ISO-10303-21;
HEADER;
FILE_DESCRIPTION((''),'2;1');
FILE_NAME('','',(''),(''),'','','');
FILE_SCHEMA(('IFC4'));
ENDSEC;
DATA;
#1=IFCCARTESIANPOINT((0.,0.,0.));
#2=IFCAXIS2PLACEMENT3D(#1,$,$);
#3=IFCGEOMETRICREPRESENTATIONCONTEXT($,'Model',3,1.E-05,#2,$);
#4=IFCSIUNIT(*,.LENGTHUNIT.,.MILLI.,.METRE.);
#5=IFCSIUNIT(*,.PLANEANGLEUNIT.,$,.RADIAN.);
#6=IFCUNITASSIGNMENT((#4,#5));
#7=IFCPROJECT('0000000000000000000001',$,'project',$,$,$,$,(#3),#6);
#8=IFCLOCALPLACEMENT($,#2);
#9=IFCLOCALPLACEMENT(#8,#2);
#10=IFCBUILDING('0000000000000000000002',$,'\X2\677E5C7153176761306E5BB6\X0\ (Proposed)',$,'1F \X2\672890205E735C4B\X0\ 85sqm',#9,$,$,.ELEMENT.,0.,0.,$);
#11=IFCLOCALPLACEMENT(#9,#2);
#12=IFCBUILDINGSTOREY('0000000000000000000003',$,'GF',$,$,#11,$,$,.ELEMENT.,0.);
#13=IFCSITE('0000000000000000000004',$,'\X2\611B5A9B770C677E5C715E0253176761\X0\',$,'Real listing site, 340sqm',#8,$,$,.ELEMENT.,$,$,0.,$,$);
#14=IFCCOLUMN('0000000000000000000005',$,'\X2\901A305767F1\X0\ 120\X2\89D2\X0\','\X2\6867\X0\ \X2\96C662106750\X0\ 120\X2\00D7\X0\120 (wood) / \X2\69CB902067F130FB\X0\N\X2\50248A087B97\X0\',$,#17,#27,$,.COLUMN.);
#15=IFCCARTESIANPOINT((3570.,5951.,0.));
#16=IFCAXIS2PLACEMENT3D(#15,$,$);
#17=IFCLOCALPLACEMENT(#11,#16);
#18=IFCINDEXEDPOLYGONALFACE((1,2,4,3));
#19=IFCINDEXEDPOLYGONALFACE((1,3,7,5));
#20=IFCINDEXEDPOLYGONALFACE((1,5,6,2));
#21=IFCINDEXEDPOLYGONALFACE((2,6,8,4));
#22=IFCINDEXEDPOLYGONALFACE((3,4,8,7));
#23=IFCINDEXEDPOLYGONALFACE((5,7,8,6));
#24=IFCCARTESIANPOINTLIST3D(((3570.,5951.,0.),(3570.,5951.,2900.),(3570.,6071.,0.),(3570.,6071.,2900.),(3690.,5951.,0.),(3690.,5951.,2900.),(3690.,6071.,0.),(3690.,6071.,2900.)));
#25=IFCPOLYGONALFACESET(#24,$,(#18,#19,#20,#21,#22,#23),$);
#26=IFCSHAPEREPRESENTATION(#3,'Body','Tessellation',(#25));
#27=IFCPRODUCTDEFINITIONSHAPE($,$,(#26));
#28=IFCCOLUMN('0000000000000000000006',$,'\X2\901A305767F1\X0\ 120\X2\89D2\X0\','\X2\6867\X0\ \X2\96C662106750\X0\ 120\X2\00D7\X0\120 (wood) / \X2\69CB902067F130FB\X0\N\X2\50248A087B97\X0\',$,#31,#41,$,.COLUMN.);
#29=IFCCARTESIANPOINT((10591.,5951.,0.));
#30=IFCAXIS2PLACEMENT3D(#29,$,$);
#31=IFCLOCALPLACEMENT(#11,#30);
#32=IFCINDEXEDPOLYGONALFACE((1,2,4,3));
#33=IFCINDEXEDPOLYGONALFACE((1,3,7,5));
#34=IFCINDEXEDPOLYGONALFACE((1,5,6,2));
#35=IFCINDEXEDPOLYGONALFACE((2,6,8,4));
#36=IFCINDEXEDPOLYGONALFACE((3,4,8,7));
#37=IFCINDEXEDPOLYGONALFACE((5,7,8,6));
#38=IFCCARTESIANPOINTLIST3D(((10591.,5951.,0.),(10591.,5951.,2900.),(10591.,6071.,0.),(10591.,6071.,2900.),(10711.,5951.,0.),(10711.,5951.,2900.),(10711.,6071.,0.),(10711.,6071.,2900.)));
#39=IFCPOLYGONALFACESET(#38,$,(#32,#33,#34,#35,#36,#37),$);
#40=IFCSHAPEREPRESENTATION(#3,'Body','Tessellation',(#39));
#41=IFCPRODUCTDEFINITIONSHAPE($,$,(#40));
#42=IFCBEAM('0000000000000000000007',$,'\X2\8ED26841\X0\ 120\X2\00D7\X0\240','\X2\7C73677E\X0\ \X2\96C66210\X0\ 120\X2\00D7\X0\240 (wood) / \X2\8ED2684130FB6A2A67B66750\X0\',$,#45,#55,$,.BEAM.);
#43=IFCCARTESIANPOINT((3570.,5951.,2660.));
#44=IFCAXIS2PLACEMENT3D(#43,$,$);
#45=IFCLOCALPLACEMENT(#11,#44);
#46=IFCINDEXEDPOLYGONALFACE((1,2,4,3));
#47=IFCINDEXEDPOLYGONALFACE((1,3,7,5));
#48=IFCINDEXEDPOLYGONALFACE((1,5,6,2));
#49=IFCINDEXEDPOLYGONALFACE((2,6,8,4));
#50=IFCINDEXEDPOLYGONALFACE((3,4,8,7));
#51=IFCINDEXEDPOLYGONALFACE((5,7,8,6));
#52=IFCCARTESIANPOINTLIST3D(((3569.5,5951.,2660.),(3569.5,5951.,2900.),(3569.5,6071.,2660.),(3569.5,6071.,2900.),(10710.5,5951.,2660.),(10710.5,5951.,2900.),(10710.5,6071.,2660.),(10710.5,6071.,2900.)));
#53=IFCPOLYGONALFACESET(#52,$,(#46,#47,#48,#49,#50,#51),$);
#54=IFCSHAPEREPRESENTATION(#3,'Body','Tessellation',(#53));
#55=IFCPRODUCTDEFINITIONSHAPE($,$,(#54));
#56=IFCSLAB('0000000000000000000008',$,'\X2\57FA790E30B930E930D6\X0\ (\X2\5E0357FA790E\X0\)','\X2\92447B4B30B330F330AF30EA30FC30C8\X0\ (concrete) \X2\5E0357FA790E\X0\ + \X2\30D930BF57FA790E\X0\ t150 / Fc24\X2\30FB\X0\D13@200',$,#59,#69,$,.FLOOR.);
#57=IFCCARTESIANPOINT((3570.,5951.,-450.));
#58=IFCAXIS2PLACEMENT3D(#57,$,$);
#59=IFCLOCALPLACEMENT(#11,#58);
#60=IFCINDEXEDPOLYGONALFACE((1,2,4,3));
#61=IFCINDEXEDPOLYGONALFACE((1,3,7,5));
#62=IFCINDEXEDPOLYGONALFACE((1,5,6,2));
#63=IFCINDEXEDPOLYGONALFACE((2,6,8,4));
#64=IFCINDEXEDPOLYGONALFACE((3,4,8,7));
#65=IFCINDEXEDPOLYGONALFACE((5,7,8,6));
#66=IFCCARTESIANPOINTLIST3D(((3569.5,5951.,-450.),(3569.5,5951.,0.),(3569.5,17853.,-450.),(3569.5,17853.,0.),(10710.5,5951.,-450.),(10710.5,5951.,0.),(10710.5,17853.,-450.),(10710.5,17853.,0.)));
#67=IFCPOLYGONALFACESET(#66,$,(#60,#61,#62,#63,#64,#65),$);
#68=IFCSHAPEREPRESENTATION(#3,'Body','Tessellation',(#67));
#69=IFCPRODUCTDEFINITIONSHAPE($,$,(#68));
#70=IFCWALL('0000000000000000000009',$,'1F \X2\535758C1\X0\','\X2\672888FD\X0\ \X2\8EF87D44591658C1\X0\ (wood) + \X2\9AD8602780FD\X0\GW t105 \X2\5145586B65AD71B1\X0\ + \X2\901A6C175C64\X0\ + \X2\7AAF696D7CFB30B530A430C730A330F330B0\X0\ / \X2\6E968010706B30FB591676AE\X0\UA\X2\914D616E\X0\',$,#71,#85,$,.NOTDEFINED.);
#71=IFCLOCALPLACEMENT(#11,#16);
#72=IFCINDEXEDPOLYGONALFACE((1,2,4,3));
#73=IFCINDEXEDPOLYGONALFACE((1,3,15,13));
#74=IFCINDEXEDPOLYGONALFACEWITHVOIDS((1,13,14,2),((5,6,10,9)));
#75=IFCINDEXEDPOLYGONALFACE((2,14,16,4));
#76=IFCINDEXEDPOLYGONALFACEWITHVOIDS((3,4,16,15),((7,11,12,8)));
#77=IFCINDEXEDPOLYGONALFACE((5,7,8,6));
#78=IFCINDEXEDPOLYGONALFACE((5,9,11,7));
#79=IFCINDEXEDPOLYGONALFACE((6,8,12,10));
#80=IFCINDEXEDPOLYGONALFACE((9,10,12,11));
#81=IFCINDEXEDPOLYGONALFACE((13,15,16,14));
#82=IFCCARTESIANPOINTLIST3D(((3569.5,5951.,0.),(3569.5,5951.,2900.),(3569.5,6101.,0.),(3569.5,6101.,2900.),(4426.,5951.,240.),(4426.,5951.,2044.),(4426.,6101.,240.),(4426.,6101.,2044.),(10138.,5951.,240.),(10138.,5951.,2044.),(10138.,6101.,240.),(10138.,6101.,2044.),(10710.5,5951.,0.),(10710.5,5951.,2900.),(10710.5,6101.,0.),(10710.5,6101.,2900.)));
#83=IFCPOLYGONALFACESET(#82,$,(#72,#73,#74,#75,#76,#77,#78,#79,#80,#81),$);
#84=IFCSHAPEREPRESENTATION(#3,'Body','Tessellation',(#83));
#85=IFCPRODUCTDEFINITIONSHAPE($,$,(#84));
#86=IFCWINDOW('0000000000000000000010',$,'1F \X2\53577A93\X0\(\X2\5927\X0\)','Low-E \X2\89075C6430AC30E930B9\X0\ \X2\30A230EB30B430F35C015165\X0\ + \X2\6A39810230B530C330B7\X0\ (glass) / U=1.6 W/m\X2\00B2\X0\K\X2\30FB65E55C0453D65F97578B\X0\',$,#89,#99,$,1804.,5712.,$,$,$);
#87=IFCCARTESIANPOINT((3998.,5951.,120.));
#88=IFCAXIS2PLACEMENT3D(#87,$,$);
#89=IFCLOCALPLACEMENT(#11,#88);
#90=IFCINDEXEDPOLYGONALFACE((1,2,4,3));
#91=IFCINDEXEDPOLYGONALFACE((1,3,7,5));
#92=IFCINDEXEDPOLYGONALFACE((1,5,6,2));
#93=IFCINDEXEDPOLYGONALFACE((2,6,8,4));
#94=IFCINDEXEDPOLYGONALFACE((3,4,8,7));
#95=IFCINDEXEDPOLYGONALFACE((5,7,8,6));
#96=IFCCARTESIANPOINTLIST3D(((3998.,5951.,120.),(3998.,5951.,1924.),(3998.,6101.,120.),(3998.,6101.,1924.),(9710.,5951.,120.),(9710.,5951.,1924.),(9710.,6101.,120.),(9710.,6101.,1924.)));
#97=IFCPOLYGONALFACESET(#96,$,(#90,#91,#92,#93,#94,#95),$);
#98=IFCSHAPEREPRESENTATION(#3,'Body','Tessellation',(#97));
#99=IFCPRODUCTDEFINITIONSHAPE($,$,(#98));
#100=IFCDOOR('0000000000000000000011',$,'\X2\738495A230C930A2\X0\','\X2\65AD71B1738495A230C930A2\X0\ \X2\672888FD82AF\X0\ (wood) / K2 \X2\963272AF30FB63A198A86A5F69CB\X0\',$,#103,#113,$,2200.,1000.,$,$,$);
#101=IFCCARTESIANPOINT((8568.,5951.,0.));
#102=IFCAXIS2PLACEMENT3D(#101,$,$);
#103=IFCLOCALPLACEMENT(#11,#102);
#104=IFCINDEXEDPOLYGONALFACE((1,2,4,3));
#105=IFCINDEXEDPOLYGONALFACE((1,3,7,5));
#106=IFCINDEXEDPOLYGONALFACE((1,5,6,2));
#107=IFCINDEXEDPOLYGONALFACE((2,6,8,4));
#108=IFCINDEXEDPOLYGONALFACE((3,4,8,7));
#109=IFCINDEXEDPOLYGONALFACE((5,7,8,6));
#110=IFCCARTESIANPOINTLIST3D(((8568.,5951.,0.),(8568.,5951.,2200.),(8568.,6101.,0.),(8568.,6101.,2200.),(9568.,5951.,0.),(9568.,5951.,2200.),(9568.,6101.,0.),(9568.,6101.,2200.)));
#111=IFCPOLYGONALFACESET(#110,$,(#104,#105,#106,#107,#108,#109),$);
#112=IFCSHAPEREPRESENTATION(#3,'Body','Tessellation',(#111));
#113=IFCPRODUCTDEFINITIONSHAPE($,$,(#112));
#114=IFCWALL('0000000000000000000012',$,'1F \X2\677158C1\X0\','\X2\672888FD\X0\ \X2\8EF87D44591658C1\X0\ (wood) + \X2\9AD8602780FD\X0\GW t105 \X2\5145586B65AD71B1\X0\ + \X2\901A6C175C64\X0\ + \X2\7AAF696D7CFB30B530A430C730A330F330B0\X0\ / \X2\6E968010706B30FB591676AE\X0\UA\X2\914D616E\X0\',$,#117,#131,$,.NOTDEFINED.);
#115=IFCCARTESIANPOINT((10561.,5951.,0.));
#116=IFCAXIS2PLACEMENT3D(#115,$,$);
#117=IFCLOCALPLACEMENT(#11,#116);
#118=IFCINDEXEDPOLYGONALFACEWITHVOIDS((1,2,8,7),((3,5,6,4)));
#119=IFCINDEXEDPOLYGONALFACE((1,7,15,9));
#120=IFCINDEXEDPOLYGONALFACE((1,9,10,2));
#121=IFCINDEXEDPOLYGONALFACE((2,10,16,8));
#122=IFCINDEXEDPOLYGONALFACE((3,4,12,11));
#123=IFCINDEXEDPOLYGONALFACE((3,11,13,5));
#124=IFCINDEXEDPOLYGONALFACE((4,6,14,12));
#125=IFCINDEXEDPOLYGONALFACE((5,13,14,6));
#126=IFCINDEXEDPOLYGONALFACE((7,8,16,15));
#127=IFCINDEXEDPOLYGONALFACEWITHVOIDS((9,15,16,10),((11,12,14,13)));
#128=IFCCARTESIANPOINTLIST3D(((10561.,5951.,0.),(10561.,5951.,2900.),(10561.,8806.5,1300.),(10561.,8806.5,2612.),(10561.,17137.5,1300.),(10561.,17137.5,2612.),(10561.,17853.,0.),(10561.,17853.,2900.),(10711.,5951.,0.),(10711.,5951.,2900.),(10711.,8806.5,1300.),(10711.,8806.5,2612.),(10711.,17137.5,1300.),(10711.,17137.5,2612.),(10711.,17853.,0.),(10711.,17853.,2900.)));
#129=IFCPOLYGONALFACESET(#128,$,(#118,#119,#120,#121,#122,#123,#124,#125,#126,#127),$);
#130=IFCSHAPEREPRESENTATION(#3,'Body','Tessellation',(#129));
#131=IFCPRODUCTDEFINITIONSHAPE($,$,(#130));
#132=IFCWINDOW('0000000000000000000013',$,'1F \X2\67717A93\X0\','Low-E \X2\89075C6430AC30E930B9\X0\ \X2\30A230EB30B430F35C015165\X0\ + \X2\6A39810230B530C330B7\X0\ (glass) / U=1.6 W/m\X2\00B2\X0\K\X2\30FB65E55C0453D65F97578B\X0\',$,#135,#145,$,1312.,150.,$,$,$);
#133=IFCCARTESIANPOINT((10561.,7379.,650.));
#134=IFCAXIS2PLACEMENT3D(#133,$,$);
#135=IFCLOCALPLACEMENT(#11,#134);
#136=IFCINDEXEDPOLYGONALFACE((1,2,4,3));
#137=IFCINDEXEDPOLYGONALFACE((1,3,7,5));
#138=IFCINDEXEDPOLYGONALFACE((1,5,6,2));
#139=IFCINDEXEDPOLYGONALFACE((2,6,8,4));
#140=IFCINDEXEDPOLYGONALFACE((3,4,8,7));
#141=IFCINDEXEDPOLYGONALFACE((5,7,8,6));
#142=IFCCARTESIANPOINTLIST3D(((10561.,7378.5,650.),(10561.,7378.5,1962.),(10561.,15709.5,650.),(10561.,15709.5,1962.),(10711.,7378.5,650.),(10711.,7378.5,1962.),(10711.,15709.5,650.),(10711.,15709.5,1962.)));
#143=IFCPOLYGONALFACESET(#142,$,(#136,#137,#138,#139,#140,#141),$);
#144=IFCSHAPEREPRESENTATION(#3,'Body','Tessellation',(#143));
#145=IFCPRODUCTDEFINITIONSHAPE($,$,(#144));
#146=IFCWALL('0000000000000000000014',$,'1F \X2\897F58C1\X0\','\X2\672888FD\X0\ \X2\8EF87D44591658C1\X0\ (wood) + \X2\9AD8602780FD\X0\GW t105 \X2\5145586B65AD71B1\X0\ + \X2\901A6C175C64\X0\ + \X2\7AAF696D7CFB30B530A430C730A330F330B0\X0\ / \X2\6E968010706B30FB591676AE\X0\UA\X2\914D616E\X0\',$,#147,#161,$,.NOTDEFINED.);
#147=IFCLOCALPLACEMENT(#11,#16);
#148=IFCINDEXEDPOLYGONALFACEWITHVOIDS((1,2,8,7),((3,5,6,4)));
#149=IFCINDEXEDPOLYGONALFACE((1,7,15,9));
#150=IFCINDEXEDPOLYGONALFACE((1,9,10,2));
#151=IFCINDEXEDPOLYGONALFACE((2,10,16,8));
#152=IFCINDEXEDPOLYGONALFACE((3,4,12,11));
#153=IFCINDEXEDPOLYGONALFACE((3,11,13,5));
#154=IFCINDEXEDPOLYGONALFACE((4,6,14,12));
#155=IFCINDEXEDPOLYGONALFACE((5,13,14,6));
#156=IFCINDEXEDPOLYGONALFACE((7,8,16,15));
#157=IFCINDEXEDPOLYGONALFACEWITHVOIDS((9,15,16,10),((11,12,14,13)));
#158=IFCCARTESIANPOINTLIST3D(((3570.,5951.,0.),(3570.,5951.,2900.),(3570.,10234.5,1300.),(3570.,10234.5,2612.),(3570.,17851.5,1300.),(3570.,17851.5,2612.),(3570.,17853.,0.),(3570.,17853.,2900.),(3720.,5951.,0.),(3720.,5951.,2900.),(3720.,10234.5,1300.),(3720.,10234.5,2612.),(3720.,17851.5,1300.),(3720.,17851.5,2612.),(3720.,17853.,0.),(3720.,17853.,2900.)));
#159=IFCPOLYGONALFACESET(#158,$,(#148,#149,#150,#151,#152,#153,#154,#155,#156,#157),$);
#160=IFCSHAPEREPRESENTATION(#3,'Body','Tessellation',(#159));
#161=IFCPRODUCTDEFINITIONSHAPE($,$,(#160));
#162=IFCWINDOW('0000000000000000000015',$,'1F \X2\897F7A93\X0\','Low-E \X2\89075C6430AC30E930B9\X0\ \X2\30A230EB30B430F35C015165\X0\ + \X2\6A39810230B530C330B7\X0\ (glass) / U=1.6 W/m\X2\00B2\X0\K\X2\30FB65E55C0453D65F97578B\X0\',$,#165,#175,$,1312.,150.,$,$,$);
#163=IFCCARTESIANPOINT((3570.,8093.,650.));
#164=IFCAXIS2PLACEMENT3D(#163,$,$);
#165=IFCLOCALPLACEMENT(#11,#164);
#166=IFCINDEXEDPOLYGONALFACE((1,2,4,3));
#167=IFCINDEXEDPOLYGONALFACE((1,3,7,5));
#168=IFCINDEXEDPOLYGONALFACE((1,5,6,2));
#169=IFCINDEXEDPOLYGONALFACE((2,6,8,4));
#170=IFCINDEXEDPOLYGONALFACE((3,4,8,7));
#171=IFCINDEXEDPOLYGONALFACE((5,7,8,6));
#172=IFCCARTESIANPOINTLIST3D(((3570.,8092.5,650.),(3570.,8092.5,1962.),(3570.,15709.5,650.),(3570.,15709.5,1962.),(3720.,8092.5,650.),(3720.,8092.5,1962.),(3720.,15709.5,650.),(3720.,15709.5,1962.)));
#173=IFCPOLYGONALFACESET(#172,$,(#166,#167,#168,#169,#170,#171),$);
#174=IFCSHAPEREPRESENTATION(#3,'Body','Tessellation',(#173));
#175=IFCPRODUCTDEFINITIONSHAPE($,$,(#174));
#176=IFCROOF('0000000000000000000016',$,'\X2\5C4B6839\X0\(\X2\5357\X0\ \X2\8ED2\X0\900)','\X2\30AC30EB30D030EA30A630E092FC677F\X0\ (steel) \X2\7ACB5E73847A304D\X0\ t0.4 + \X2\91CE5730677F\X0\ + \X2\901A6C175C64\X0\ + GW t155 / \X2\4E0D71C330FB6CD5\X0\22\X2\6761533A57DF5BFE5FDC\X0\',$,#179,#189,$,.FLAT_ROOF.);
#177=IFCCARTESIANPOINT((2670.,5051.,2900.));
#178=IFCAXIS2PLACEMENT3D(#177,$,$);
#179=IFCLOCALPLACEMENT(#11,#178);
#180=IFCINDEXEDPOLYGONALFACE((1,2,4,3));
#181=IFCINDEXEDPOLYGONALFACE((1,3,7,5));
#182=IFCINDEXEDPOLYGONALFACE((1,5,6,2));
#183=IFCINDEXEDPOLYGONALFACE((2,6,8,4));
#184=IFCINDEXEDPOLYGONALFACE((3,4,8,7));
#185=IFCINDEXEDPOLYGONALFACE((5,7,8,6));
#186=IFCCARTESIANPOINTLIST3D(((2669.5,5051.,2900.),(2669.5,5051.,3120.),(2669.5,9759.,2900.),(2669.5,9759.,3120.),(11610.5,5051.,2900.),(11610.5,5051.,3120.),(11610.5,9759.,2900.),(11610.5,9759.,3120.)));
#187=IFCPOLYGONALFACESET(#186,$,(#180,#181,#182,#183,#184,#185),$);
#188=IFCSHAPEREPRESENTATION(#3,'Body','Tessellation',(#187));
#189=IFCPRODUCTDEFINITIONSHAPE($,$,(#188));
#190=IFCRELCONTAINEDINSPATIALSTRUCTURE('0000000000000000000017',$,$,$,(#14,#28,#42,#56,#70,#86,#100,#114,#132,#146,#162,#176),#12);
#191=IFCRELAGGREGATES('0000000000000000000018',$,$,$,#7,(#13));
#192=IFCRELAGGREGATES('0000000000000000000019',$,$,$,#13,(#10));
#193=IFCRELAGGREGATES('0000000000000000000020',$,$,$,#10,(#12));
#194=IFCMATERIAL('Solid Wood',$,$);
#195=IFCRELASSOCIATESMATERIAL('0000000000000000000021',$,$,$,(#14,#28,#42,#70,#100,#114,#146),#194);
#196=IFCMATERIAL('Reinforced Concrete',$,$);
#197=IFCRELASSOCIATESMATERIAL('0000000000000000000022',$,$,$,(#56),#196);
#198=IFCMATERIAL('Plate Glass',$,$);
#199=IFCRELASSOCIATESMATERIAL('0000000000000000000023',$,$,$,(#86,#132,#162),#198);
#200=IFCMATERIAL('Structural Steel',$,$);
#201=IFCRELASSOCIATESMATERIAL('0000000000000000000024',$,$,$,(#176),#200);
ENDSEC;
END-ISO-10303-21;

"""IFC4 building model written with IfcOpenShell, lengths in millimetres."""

from ifc_helpers import new_model, si_unit, frame, frame_2d, origin, place, context, project, spatial, rectangle, extrude, material, element, fill, save


model = new_model("IFC4")

# Units and contexts
model_context = context("Model", 3, precision=1e-05, world=origin())
ifc_project = project(units=[si_unit("LENGTHUNIT", "METRE", prefix="MILLI"), si_unit("PLANEANGLEUNIT", "RADIAN")], contexts=[model_context])

# Site, building, storey
site_placement = place(None, origin())
site = spatial("IfcSite", under=ifc_project, at=site_placement, Name="愛媛県松山市北条", ObjectType="Real listing site, 340sqm", CompositionType="ELEMENT", RefElevation=0.0)
building_placement = place(site_placement, origin())
building = spatial("IfcBuilding", under=site, at=building_placement, Name="松山北条の家 (Proposed)", ObjectType="1F 木造平屋 85sqm", CompositionType="ELEMENT", ElevationOfRefHeight=0.0, ElevationOfTerrain=0.0)
storey_placement = place(building_placement, origin())
storey = spatial("IfcBuildingStorey", under=building, at=storey_placement, Name="GF", CompositionType="ELEMENT", Elevation=0.0)

# Columns
ifc_material_1 = material(Name="Solid Wood")
column_1_placement = place(storey_placement, frame((3570.0, 5951.0, 0.0)))
element("IfcColumn", 1, at=column_1_placement, inside=storey, material=ifc_material_1, Name="通し柱 120角", Description="桧 集成材 120×120 (wood) / 構造柱・N値計算", PredefinedType="COLUMN", context=model_context, shape_type="SweptSolid", body=[
    extrude(rectangle(XDim=120.0, YDim=120.0, at=frame_2d((60.0, 60.0))), frame((3570.0, 5951.0, 0.0)), (0.0, 0.0, 1.0), 2900.0),
])
column_2_placement = place(storey_placement, frame((10591.0, 5951.0, 0.0)))
element("IfcColumn", 2, at=column_2_placement, inside=storey, material=ifc_material_1, Name="通し柱 120角", Description="桧 集成材 120×120 (wood) / 構造柱・N値計算", PredefinedType="COLUMN", context=model_context, shape_type="SweptSolid", body=[
    extrude(rectangle(XDim=120.0, YDim=120.0, at=frame_2d((60.0, 60.0))), frame((10591.0, 5951.0, 0.0)), (0.0, 0.0, 1.0), 2900.0),
])

# Beam
beam_1_placement = place(storey_placement, frame((3570.0, 5951.0, 2660.0)))
element("IfcBeam", 3, at=beam_1_placement, inside=storey, material=ifc_material_1, Name="軒桁 120×240", Description="米松 集成 120×240 (wood) / 軒桁・横架材", PredefinedType="BEAM", context=model_context, shape_type="SweptSolid", body=[
    extrude(rectangle(XDim=7141.0, YDim=120.0, at=frame_2d((3570.0, 60.0))), frame((3570.0, 5951.0, 2660.0)), (0.0, 0.0, 1.0), 240.0),
])

# Slab
ifc_material_2 = material(Name="Reinforced Concrete")
slab_1_placement = place(storey_placement, frame((3570.0, 5951.0, -450.0)))
element("IfcSlab", 4, at=slab_1_placement, inside=storey, material=ifc_material_2, Name="基礎スラブ (布基礎)", Description="鉄筋コンクリート (concrete) 布基礎 + ベタ基礎 t150 / Fc24・D13@200", PredefinedType="FLOOR", context=model_context, shape_type="SweptSolid", body=[
    extrude(rectangle(XDim=7141.0, YDim=11902.0, at=frame_2d((3570.0, 5951.0))), frame((3570.0, 5951.0, -450.0)), (0.0, 0.0, 1.0), 450.0),
])

# Wall, openings, window, door
wall_1_placement = place(storey_placement, frame((3570.0, 5951.0, 0.0)))
wall_1 = element("IfcWall", 5, at=wall_1_placement, inside=storey, material=ifc_material_1, Name="1F 南壁", Description="木製 軸組外壁 (wood) + 高性能GW t105 充填断熱 + 通気層 + 窯業系サイディング / 準耐火・外皮UA配慮", PredefinedType="NOTDEFINED", context=model_context, shape_type="SweptSolid", body=[
    extrude(rectangle(XDim=7141.0, YDim=150.0, at=frame_2d((3570.0, 75.0))), frame((3570.0, 5951.0, 0.0)), (0.0, 0.0, 1.0), 2900.0),
])
opening_1_placement = place(storey_placement, frame((3998.0, 5951.0, 120.0)))
opening_1 = element("IfcOpeningElement", 6, at=opening_1_placement, cuts=wall_1, PredefinedType="NOTDEFINED", context=model_context, shape_type="SweptSolid", body=[
    extrude(rectangle(XDim=5712.0, YDim=150.0, at=frame_2d((2856.0, 75.0))), frame((3998.0, 5951.0, 120.0)), (0.0, 0.0, 1.0), 1804.0),
])
opening_2_placement = place(storey_placement, frame((8568.0, 5951.0, 0.0)))
opening_2 = element("IfcOpeningElement", 7, at=opening_2_placement, cuts=wall_1, PredefinedType="NOTDEFINED", context=model_context, shape_type="SweptSolid", body=[
    extrude(rectangle(XDim=1000.0, YDim=150.0, at=frame_2d((500.0, 75.0))), frame((8568.0, 5951.0, 0.0)), (0.0, 0.0, 1.0), 2200.0),
])
ifc_material_3 = material(Name="Plate Glass")
window_1_placement = place(storey_placement, frame((3998.0, 5951.0, 120.0)))
window_1 = element("IfcWindow", 8, at=window_1_placement, inside=storey, material=ifc_material_3, Name="1F 南窓(大)", Description="Low-E 複層ガラス アルゴン封入 + 樹脂サッシ (glass) / U=1.6 W/m²K・日射取得型", OverallHeight=1804.0, OverallWidth=5712.0, context=model_context, shape_type="SweptSolid", body=[
    extrude(rectangle(XDim=5712.0, YDim=150.0, at=frame_2d((2856.0, 75.0))), frame((3998.0, 5951.0, 120.0)), (0.0, 0.0, 1.0), 1804.0),
])
fill(opening_1, window_1)
door_placement = place(storey_placement, frame((8568.0, 5951.0, 0.0)))
door = element("IfcDoor", 9, at=door_placement, inside=storey, material=ifc_material_1, Name="玄関ドア", Description="断熱玄関ドア 木製芯 (wood) / K2 防犯・採風機構", OverallHeight=2200.0, OverallWidth=1000.0, context=model_context, shape_type="SweptSolid", body=[
    extrude(rectangle(XDim=1000.0, YDim=150.0, at=frame_2d((500.0, 75.0))), frame((8568.0, 5951.0, 0.0)), (0.0, 0.0, 1.0), 2200.0),
])
fill(opening_2, door)

# Walls, openings, windows
wall_2_placement = place(storey_placement, frame((10561.0, 5951.0, 0.0)))
wall_2 = element("IfcWall", 10, at=wall_2_placement, inside=storey, material=ifc_material_1, Name="1F 東壁", Description="木製 軸組外壁 (wood) + 高性能GW t105 充填断熱 + 通気層 + 窯業系サイディング / 準耐火・外皮UA配慮", PredefinedType="NOTDEFINED", context=model_context, shape_type="SweptSolid", body=[
    extrude(rectangle(XDim=150.0, YDim=11902.0, at=frame_2d((75.0, 5951.0))), frame((10561.0, 5951.0, 0.0)), (0.0, 0.0, 1.0), 2900.0),
])
opening_3_placement = place(storey_placement, frame((10561.0, 7379.0, 650.0)))
opening_3 = element("IfcOpeningElement", 11, at=opening_3_placement, cuts=wall_2, PredefinedType="NOTDEFINED", context=model_context, shape_type="SweptSolid", body=[
    extrude(rectangle(XDim=150.0, YDim=8331.0, at=frame_2d((75.0, 4165.0))), frame((10561.0, 7379.0, 650.0)), (0.0, 0.0, 1.0), 1312.0),
])
window_2_placement = place(storey_placement, frame((10561.0, 7379.0, 650.0)))
window_2 = element("IfcWindow", 12, at=window_2_placement, inside=storey, material=ifc_material_3, Name="1F 東窓", Description="Low-E 複層ガラス アルゴン封入 + 樹脂サッシ (glass) / U=1.6 W/m²K・日射取得型", OverallHeight=1312.0, OverallWidth=150.0, context=model_context, shape_type="SweptSolid", body=[
    extrude(rectangle(XDim=150.0, YDim=8331.0, at=frame_2d((75.0, 4165.0))), frame((10561.0, 7379.0, 650.0)), (0.0, 0.0, 1.0), 1312.0),
])
fill(opening_3, window_2)
wall_3_placement = place(storey_placement, frame((3570.0, 5951.0, 0.0)))
wall_3 = element("IfcWall", 13, at=wall_3_placement, inside=storey, material=ifc_material_1, Name="1F 西壁", Description="木製 軸組外壁 (wood) + 高性能GW t105 充填断熱 + 通気層 + 窯業系サイディング / 準耐火・外皮UA配慮", PredefinedType="NOTDEFINED", context=model_context, shape_type="SweptSolid", body=[
    extrude(rectangle(XDim=150.0, YDim=11902.0, at=frame_2d((75.0, 5951.0))), frame((3570.0, 5951.0, 0.0)), (0.0, 0.0, 1.0), 2900.0),
])
opening_4_placement = place(storey_placement, frame((3570.0, 8093.0, 650.0)))
opening_4 = element("IfcOpeningElement", 14, at=opening_4_placement, cuts=wall_3, PredefinedType="NOTDEFINED", context=model_context, shape_type="SweptSolid", body=[
    extrude(rectangle(XDim=150.0, YDim=7617.0, at=frame_2d((75.0, 3808.0))), frame((3570.0, 8093.0, 650.0)), (0.0, 0.0, 1.0), 1312.0),
])
window_3_placement = place(storey_placement, frame((3570.0, 8093.0, 650.0)))
window_3 = element("IfcWindow", 15, at=window_3_placement, inside=storey, material=ifc_material_3, Name="1F 西窓", Description="Low-E 複層ガラス アルゴン封入 + 樹脂サッシ (glass) / U=1.6 W/m²K・日射取得型", OverallHeight=1312.0, OverallWidth=150.0, context=model_context, shape_type="SweptSolid", body=[
    extrude(rectangle(XDim=150.0, YDim=7617.0, at=frame_2d((75.0, 3808.0))), frame((3570.0, 8093.0, 650.0)), (0.0, 0.0, 1.0), 1312.0),
])
fill(opening_4, window_3)

# Roof
ifc_material_4 = material(Name="Structural Steel")
roof_placement = place(storey_placement, frame((2670.0, 5051.0, 2900.0)))
element("IfcRoof", 16, at=roof_placement, inside=storey, material=ifc_material_4, Name="屋根(南 軒900)", Description="ガルバリウム鋼板 (steel) 立平葺き t0.4 + 野地板 + 通気層 + GW t155 / 不燃・法22条区域対応", PredefinedType="FLAT_ROOF", context=model_context, shape_type="SweptSolid", body=[
    extrude(rectangle(XDim=8941.0, YDim=4708.0, at=frame_2d((4470.0, 2354.0))), frame((2670.0, 5051.0, 2900.0)), (0.0, 0.0, 1.0), 220.0),
])

save(model, "model.ifc")
